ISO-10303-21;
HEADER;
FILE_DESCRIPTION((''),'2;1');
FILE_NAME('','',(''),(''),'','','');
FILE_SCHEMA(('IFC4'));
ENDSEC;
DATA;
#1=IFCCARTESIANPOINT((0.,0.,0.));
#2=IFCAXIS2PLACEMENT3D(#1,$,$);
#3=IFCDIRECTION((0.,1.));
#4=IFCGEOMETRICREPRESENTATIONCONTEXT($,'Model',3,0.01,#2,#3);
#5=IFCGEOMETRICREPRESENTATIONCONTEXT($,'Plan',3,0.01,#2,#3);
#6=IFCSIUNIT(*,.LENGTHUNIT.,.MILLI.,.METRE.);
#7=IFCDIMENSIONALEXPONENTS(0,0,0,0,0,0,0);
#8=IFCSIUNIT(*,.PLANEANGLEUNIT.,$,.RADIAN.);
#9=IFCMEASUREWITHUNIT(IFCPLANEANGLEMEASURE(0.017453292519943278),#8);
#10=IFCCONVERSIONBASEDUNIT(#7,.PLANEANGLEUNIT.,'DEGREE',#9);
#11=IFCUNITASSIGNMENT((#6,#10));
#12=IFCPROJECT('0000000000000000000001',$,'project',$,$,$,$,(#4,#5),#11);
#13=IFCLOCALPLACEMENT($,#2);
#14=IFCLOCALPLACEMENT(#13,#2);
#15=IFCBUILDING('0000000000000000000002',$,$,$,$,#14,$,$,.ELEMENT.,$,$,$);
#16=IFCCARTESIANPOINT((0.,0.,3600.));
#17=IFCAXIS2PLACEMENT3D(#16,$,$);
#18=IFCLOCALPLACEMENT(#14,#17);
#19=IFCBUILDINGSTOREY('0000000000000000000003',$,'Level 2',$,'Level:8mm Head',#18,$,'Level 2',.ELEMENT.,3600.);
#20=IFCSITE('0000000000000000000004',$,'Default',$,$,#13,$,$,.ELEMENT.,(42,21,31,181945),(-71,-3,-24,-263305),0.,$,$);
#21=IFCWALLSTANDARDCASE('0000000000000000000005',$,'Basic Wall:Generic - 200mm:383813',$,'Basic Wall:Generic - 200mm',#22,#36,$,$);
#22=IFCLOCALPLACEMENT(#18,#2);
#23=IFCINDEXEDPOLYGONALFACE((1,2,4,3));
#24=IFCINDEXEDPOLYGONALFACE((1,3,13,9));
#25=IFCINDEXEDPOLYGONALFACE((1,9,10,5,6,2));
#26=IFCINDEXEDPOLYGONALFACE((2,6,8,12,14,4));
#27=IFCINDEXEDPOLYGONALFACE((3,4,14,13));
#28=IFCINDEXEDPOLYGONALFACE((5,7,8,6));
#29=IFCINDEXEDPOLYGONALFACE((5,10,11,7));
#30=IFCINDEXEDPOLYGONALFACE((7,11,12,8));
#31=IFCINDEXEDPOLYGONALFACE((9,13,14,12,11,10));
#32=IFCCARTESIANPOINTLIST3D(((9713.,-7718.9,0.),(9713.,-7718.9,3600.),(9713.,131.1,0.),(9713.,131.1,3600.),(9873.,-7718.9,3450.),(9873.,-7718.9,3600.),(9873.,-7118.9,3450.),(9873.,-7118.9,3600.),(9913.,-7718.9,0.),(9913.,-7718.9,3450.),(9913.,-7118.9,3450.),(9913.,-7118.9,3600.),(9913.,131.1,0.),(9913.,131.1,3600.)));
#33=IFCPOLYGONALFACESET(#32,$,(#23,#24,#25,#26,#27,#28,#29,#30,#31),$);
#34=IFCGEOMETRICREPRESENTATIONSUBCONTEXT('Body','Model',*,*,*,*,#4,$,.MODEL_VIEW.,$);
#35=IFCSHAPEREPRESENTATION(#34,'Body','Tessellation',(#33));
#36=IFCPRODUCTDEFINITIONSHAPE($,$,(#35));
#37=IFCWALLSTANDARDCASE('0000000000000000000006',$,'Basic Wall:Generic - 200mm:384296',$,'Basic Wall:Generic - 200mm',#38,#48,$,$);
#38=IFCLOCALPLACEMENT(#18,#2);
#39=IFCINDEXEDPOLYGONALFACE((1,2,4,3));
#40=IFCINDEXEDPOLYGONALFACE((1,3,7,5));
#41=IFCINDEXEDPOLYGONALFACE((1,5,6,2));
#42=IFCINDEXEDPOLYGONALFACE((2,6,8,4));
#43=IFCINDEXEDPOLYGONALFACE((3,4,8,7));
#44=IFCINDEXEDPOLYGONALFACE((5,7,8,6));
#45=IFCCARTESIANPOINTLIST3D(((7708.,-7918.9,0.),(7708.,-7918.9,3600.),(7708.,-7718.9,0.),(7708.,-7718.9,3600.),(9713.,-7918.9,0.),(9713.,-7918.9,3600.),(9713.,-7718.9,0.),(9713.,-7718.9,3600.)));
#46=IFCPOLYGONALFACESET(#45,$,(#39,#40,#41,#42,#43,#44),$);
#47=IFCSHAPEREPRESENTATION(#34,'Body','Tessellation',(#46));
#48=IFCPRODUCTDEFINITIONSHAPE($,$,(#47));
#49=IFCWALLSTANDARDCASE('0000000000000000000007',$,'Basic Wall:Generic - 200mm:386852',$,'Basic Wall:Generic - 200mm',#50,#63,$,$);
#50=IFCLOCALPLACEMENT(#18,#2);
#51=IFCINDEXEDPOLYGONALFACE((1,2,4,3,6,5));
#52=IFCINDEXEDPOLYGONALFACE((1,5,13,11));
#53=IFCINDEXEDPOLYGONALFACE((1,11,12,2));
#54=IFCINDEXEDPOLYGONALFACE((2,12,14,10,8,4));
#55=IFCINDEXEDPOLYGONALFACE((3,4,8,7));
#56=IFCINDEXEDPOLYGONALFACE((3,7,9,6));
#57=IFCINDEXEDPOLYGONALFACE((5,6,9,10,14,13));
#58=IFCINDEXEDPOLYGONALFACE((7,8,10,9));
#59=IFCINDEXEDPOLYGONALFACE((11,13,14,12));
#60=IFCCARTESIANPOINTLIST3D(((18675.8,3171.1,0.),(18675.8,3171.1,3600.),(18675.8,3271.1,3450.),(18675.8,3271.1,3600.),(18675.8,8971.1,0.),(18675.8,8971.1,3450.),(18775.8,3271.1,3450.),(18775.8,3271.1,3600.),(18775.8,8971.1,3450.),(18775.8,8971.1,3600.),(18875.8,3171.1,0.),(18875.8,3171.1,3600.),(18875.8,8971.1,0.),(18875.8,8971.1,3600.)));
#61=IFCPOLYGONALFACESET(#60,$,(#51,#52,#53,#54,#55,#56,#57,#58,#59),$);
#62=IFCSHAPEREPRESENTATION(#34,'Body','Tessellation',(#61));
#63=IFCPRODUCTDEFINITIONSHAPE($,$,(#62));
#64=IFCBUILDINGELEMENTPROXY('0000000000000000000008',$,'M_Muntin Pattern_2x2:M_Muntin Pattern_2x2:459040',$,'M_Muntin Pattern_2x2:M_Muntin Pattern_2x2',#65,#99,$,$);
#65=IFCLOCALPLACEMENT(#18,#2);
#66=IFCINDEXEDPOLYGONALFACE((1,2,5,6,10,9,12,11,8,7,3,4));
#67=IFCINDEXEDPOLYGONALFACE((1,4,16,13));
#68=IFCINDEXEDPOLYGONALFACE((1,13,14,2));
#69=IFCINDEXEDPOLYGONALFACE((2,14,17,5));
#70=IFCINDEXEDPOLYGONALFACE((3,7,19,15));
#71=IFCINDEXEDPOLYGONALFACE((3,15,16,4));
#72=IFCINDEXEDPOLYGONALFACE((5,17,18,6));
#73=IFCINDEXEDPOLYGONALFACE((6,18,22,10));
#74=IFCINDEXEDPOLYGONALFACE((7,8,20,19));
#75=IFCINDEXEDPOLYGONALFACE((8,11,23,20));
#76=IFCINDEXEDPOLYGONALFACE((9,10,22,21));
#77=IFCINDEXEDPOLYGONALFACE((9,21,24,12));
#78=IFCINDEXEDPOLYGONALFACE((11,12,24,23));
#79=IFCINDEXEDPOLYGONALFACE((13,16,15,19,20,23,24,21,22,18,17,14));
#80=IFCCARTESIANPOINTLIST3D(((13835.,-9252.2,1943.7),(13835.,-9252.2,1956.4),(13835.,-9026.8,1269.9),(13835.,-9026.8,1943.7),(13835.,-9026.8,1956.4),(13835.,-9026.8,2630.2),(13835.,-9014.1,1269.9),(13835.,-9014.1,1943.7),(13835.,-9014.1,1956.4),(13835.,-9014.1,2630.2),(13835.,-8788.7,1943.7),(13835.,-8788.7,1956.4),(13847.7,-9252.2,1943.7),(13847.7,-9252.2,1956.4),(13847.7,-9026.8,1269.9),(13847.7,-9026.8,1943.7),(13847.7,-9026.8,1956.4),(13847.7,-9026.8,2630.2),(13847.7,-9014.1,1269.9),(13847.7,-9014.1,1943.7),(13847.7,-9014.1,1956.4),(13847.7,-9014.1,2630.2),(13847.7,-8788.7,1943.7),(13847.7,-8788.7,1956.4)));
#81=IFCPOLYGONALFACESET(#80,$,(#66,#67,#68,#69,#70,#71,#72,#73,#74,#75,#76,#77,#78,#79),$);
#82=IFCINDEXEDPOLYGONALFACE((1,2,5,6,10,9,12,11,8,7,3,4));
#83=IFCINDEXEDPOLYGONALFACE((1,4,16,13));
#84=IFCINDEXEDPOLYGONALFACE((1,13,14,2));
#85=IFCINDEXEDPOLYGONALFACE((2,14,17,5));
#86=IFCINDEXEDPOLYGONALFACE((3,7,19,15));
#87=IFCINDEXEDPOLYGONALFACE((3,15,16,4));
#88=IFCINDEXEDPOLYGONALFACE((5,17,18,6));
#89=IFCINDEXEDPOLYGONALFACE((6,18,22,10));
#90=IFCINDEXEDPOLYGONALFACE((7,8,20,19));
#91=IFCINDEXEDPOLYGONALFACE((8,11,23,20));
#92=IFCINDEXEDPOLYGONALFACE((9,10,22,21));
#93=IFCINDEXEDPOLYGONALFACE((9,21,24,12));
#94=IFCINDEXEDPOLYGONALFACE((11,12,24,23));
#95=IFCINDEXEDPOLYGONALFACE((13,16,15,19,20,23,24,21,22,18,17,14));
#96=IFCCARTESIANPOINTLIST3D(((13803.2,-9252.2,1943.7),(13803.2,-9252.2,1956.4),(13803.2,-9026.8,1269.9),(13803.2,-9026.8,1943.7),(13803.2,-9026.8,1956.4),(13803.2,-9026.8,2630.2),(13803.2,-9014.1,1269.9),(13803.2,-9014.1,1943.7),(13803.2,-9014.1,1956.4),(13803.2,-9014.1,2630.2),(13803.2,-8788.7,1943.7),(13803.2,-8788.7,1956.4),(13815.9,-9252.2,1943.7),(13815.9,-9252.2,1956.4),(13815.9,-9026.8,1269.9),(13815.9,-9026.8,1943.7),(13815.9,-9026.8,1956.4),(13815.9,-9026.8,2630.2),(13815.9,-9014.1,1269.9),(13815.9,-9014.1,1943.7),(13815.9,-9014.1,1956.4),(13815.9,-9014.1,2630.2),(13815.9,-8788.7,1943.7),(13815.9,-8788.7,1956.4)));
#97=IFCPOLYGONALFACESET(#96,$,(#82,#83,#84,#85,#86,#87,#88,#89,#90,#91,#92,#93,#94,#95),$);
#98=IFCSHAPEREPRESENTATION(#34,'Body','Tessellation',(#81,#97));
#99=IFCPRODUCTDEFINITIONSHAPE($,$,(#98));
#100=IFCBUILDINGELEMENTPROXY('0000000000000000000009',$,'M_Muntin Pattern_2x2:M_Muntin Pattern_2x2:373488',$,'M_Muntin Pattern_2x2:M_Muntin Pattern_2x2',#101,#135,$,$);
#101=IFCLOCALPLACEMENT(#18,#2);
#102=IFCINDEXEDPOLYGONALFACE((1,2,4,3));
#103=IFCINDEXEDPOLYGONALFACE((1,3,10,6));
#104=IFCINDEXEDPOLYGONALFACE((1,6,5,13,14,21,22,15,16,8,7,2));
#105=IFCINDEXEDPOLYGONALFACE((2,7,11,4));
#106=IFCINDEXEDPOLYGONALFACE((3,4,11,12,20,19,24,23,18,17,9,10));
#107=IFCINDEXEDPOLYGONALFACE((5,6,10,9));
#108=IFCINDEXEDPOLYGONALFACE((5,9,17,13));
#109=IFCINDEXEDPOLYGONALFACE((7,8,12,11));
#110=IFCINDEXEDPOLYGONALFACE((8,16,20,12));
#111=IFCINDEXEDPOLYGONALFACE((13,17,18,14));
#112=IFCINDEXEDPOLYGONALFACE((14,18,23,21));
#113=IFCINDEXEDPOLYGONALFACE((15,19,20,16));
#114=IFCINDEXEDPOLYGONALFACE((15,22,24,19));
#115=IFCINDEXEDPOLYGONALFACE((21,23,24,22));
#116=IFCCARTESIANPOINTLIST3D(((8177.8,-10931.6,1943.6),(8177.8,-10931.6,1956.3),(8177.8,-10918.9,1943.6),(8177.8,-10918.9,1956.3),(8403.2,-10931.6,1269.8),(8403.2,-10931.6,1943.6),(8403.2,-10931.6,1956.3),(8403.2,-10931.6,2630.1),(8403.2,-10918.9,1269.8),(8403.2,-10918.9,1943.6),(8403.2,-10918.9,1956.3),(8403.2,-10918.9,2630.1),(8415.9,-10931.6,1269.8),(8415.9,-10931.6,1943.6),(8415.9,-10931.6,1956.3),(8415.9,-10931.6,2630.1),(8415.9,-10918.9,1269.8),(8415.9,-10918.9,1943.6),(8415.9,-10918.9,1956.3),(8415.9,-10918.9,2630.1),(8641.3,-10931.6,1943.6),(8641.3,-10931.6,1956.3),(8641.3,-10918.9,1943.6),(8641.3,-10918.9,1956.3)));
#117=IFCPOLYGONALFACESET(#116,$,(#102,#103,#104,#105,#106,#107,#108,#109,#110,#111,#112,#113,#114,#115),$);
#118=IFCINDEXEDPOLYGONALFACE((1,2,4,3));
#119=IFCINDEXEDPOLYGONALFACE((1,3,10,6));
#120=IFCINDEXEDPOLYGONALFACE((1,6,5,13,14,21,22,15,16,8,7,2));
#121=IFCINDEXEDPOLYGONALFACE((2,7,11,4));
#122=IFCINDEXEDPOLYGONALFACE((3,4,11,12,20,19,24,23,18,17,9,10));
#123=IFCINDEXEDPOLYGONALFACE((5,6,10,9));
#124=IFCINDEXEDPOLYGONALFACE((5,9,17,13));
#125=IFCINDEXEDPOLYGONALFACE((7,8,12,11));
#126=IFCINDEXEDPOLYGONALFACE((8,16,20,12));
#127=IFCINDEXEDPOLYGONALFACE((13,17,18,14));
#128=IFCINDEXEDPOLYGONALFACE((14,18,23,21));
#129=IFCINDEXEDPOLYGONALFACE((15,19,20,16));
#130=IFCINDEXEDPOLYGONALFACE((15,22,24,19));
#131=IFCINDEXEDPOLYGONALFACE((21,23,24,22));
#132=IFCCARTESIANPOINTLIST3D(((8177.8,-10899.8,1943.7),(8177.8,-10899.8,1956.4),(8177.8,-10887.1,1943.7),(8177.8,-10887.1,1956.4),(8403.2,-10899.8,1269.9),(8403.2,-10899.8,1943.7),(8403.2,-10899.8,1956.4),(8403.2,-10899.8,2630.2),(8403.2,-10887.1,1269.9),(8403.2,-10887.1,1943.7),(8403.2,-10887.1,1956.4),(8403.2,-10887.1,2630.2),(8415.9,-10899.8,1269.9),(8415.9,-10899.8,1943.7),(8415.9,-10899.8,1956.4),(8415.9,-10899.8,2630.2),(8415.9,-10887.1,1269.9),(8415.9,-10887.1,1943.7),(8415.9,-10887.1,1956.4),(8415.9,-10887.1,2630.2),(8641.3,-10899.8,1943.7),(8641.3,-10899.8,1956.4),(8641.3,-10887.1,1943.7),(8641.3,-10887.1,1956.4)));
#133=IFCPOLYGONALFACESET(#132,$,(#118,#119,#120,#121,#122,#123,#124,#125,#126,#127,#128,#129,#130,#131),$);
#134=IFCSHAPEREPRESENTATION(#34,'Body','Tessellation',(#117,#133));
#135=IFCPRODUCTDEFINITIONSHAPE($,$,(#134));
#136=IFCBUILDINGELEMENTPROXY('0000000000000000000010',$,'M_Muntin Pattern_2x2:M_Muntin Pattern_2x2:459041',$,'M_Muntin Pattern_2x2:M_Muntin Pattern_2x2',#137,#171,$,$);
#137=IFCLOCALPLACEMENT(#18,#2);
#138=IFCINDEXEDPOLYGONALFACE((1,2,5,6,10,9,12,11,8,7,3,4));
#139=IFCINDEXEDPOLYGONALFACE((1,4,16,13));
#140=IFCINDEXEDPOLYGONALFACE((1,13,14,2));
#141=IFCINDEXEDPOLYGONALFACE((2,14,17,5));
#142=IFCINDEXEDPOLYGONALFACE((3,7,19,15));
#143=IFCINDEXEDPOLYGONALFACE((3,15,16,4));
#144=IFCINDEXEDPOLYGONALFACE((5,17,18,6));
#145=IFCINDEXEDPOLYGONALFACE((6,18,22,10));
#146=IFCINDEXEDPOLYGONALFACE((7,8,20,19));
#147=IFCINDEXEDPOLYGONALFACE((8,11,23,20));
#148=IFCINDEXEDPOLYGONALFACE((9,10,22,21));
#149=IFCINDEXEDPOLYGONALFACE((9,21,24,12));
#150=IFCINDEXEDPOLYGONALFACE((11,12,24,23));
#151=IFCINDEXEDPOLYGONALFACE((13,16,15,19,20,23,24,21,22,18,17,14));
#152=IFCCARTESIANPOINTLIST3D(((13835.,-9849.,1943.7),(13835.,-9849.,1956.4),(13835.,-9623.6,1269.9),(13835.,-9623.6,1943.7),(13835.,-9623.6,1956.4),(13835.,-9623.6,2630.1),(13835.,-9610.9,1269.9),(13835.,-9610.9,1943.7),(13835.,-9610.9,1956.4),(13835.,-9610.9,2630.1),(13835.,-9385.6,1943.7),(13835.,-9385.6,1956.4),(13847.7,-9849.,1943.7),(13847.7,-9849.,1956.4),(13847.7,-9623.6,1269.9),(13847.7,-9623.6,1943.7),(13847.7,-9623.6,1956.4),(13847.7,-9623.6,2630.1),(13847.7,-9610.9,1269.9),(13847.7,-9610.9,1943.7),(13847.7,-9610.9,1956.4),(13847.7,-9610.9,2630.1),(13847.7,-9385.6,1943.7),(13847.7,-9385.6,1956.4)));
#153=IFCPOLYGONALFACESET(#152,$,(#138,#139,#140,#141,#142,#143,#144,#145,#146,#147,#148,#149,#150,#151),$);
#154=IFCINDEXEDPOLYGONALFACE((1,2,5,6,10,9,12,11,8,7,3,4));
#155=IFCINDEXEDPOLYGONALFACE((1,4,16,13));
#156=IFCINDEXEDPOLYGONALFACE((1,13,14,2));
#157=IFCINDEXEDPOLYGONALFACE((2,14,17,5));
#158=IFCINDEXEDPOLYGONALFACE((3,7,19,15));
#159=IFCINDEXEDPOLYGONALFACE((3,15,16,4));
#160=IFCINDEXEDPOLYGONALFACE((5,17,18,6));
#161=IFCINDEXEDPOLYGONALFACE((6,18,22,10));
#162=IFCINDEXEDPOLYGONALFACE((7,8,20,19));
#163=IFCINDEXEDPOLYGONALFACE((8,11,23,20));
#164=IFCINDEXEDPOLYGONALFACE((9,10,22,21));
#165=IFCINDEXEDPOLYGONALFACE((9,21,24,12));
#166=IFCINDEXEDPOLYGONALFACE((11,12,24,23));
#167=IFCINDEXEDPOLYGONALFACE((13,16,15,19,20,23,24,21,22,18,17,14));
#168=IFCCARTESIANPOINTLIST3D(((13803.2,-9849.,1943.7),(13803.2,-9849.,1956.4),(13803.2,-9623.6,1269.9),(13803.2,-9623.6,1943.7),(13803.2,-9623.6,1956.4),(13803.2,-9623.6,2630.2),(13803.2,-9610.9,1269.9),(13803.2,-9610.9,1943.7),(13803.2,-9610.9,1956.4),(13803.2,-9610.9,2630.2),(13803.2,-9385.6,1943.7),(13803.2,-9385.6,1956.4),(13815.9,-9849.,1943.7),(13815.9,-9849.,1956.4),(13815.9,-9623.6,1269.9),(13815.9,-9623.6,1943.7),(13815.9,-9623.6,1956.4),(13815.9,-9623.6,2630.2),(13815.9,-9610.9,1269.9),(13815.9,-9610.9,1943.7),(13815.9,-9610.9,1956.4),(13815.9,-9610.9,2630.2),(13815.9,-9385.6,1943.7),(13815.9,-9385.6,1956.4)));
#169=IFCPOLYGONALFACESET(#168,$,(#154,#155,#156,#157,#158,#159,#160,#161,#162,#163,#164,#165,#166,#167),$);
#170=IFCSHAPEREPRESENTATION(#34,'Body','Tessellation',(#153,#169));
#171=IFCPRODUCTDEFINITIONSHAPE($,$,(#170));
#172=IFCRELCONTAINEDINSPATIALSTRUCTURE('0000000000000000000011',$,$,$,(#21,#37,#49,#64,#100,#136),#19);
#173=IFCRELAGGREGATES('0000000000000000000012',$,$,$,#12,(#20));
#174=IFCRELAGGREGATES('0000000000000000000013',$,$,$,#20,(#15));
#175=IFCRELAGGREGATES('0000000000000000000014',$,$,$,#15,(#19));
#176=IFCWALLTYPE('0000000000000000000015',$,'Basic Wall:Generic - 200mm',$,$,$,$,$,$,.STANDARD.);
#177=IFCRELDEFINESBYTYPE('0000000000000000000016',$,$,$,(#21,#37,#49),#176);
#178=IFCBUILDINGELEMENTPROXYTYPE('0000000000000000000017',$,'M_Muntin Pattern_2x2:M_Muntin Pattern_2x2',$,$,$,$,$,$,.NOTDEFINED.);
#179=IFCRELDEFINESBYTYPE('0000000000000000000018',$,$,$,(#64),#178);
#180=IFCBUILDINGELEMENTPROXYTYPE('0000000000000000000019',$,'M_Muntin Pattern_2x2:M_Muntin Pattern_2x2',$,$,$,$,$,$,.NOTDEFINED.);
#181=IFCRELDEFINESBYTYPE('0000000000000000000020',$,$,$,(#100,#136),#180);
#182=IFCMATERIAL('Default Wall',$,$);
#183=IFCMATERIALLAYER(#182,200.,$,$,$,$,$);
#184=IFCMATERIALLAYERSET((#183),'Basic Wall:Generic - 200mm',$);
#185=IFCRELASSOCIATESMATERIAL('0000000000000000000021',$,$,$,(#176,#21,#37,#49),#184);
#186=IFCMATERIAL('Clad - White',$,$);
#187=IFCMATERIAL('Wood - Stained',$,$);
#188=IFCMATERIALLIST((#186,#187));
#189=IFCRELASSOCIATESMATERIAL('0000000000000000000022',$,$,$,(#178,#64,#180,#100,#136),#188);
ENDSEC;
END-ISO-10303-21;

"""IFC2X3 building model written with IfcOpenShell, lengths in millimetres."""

from ifc_helpers import new_model, entity, si_unit, converted_unit, direction, frame, frame_2d, origin, place, context, subcontext, project, spatial, polyline, rectangle, outline, extrude, clip, bounded_halfspace, source, transform, mapped, material, material_list, layer, layer_set, layer_usage, type_object, type_shapes, element, save


model = new_model("IFC2X3")

# Units and contexts
model_context = context("Model", 3, precision=0.01, world=origin(), true_north=direction((0.0, 1.0)))
plan_context = context("Plan", 3, precision=0.01, world=origin(), true_north=direction((0.0, 1.0)))
body_context = subcontext(model_context, "Body", "Model", "MODEL_VIEW")
ifc_project = project(units=[si_unit("LENGTHUNIT", "METRE", prefix="MILLI"), converted_unit("PLANEANGLEUNIT", "DEGREE", entity("IfcPlaneAngleMeasure", 0.017453292519943278), si_unit("PLANEANGLEUNIT", "RADIAN"), dimensions=[0, 0, 0, 0, 0, 0, 0])], contexts=[model_context, plan_context])

# Site, building, storey
site_placement = place(None, origin())
site = spatial("IfcSite", under=ifc_project, at=site_placement, Name="Default", CompositionType="ELEMENT", RefLatitude=(42, 21, 31, 181945), RefLongitude=(-71, -3, -24, -263305), RefElevation=0.0)
building_placement = place(site_placement, origin())
building = spatial("IfcBuilding", under=site, at=building_placement, CompositionType="ELEMENT")
storey_placement = place(building_placement, frame((0.0, 0.0, 3600.0)))
storey = spatial("IfcBuildingStorey", under=building, at=storey_placement, Name="Level 2", ObjectType="Level:8mm Head", LongName="Level 2", CompositionType="ELEMENT", Elevation=3600.0)

# Shared definitions
ifc_material_1 = material(Name="Default Wall")
ifc_layer = layer(ifc_material_1, 200.0)
ifc_layer_set = layer_set([ifc_layer], Name="Basic Wall:Generic - 200mm")
wall_type = type_object("IfcWallType", Name="Basic Wall:Generic - 200mm", PredefinedType="STANDARD", material=ifc_layer_set)

# Walls
ifc_layer_usage_1 = layer_usage(ifc_layer_set, "AXIS2", "NEGATIVE", 100.0)
wall_1_placement = place(storey_placement, frame((9813.0, 131.1, 0.0), z_axis=(0.0, 0.0, 1.0), x_axis=(0.0, -1.0, 0.0)))
element("IfcWallStandardCase", 1, at=wall_1_placement, inside=storey, type_object=wall_type, material=ifc_layer_usage_1, Name="Basic Wall:Generic - 200mm:383813", ObjectType="Basic Wall:Generic - 200mm", context=body_context, shape_type="Clipping", body=[
    clip(extrude(rectangle(XDim=7850.0, YDim=200.0, at=frame_2d((3925.0, 0.0), x_axis=(-1.0, 0.0))), origin(), (0.0, 0.0, 1.0), 3600.0), bounded_halfspace(frame((7850.0, 60.0, 3450.0), z_axis=(0.0, 0.0, -1.0), x_axis=(1.0, 0.0, 0.0)), True, frame((7850.0, 60.0, 3450.0)), polyline([(0.0, 0.0), (0.0, 40.0), (-600.0, 40.0), (-600.0, 0.0), (0.0, 0.0)]))),
])
ifc_layer_usage_2 = layer_usage(ifc_layer_set, "AXIS2", "NEGATIVE", 100.0)
wall_2_placement = place(storey_placement, frame((9713.0, -7818.9, 0.0), z_axis=(0.0, 0.0, 1.0), x_axis=(-1.0, 0.0, 0.0)))
element("IfcWallStandardCase", 2, at=wall_2_placement, inside=storey, type_object=wall_type, material=ifc_layer_usage_2, Name="Basic Wall:Generic - 200mm:384296", ObjectType="Basic Wall:Generic - 200mm", context=body_context, shape_type="SweptSolid", body=[
    extrude(rectangle(XDim=2005.0, YDim=200.0, at=frame_2d((1002.5, 0.0), x_axis=(-1.0, 0.0))), origin(), (0.0, 0.0, 1.0), 3600.0),
])
ifc_layer_usage_3 = layer_usage(ifc_layer_set, "AXIS2", "NEGATIVE", 100.0)
wall_3_placement = place(storey_placement, frame((18775.8, 8971.1, 0.0), z_axis=(0.0, 0.0, 1.0), x_axis=(0.0, -1.0, 0.0)))
element("IfcWallStandardCase", 3, at=wall_3_placement, inside=storey, type_object=wall_type, material=ifc_layer_usage_3, Name="Basic Wall:Generic - 200mm:386852", ObjectType="Basic Wall:Generic - 200mm", context=body_context, shape_type="Clipping", body=[
    clip(extrude(rectangle(XDim=5800.0, YDim=200.0, at=frame_2d((2900.0, 0.0), x_axis=(-1.0, 0.0))), origin(), (0.0, 0.0, 1.0), 3600.0), bounded_halfspace(frame((0.0, -100.0, 3450.0), z_axis=(0.0, 0.0, -1.0), x_axis=(1.0, 0.0, 0.0)), True, frame((0.0, -100.0, 3450.0)), polyline([(0.0, 0.0), (5600.0, 0.0), (5700.0, 0.0), (5700.0, 100.0), (0.0, 100.0), (0.0, 0.0)]))),
])

# Building element proxies
ifc_material_2 = material(Name="Clad - White")
ifc_material_3 = material(Name="Wood - Stained")
ifc_material_list_1 = material_list([ifc_material_2, ifc_material_3])
building_element_proxy_type_1 = type_object("IfcBuildingElementProxyType", Name="M_Muntin Pattern_2x2:M_Muntin Pattern_2x2", PredefinedType="NOTDEFINED", material=ifc_material_list_1)
shared_shape_1 = source(origin(), body_context, "Body", "SweptSolid", [
    extrude(outline(polyline([(6.4, -6.4), (680.1, -6.4), (680.1, 6.3), (6.4, 6.3), (6.4, 231.7), (-6.3, 231.7), (-6.3, 6.3), (-680.2, 6.3), (-680.2, -6.4), (-6.3, -6.4), (-6.3, -231.7), (6.4, -231.7), (6.4, -6.4)])), frame((0.0, 9.5, 680.1), z_axis=(0.0, 1.0, 0.0), x_axis=(0.0, 0.0, 1.0)), (0.0, 0.0, 1.0), 12.7),
    extrude(outline(polyline([(6.4, -6.4), (680.2, -6.4), (680.2, 6.3), (6.4, 6.3), (6.4, 231.7), (-6.3, 231.7), (-6.3, 6.3), (-680.2, 6.3), (-680.2, -6.4), (-6.3, -6.4), (-6.3, -231.7), (6.4, -231.7), (6.4, -6.4)])), frame((0.0, -22.2, 680.2), z_axis=(0.0, 1.0, 0.0), x_axis=(0.0, 0.0, 1.0)), (0.0, 0.0, 1.0), 12.7),
])
type_shapes(building_element_proxy_type_1, [shared_shape_1])
proxy_1_placement = place(storey_placement, frame((13825.5, -9020.5, 1269.9), z_axis=(0.0, 0.0, 1.0), x_axis=(0.0, -1.0, 0.0)))
element("IfcBuildingElementProxy", 4, at=proxy_1_placement, inside=storey, type_object=building_element_proxy_type_1, material=ifc_material_list_1, Name="M_Muntin Pattern_2x2:M_Muntin Pattern_2x2:459040", ObjectType="M_Muntin Pattern_2x2:M_Muntin Pattern_2x2", context=body_context, shape_type="MappedRepresentation", body=[
    mapped(shared_shape_1, transform((0.0, 0.0, 0.0), scale=1.0)),
])
building_element_proxy_type_2 = type_object("IfcBuildingElementProxyType", Name="M_Muntin Pattern_2x2:M_Muntin Pattern_2x2", PredefinedType="NOTDEFINED", material=ifc_material_list_1)
shared_shape_2 = source(origin(), body_context, "Body", "SweptSolid", [
    extrude(outline(polyline([(6.4, -6.4), (680.1, -6.4), (680.1, 6.3), (6.4, 6.3), (6.4, 231.7), (-6.3, 231.7), (-6.3, 6.3), (-680.2, 6.3), (-680.2, -6.4), (-6.3, -6.4), (-6.3, -231.7), (6.4, -231.7), (6.4, -6.4)])), frame((0.0, -22.2, 680.1), z_axis=(0.0, 1.0, 0.0), x_axis=(0.0, 0.0, 1.0)), (0.0, 0.0, 1.0), 12.7),
    extrude(outline(polyline([(6.4, -6.4), (680.2, -6.4), (680.2, 6.3), (6.4, 6.3), (6.4, 231.7), (-6.3, 231.7), (-6.3, 6.3), (-680.2, 6.3), (-680.2, -6.4), (-6.3, -6.4), (-6.3, -231.7), (6.4, -231.7), (6.4, -6.4)])), frame((0.0, 9.5, 680.2), z_axis=(0.0, 1.0, 0.0), x_axis=(0.0, 0.0, 1.0)), (0.0, 0.0, 1.0), 12.7),
])
type_shapes(building_element_proxy_type_2, [shared_shape_2])
proxy_2_placement = place(storey_placement, frame((8409.6, -10909.4, 1269.9)))
element("IfcBuildingElementProxy", 5, at=proxy_2_placement, inside=storey, type_object=building_element_proxy_type_2, material=ifc_material_list_1, Name="M_Muntin Pattern_2x2:M_Muntin Pattern_2x2:373488", ObjectType="M_Muntin Pattern_2x2:M_Muntin Pattern_2x2", context=body_context, shape_type="MappedRepresentation", body=[
    mapped(shared_shape_2, transform((0.0, 0.0, 0.0), scale=1.0)),
])
proxy_3_placement = place(storey_placement, frame((13825.5, -9617.3, 1269.9), z_axis=(0.0, 0.0, 1.0), x_axis=(0.0, 1.0, 0.0)))
element("IfcBuildingElementProxy", 6, at=proxy_3_placement, inside=storey, type_object=building_element_proxy_type_2, material=ifc_material_list_1, Name="M_Muntin Pattern_2x2:M_Muntin Pattern_2x2:459041", ObjectType="M_Muntin Pattern_2x2:M_Muntin Pattern_2x2", context=body_context, shape_type="MappedRepresentation", body=[
    mapped(shared_shape_2, transform((0.0, 0.0, 0.0), scale=1.0)),
])

save(model, "model.ifc")
